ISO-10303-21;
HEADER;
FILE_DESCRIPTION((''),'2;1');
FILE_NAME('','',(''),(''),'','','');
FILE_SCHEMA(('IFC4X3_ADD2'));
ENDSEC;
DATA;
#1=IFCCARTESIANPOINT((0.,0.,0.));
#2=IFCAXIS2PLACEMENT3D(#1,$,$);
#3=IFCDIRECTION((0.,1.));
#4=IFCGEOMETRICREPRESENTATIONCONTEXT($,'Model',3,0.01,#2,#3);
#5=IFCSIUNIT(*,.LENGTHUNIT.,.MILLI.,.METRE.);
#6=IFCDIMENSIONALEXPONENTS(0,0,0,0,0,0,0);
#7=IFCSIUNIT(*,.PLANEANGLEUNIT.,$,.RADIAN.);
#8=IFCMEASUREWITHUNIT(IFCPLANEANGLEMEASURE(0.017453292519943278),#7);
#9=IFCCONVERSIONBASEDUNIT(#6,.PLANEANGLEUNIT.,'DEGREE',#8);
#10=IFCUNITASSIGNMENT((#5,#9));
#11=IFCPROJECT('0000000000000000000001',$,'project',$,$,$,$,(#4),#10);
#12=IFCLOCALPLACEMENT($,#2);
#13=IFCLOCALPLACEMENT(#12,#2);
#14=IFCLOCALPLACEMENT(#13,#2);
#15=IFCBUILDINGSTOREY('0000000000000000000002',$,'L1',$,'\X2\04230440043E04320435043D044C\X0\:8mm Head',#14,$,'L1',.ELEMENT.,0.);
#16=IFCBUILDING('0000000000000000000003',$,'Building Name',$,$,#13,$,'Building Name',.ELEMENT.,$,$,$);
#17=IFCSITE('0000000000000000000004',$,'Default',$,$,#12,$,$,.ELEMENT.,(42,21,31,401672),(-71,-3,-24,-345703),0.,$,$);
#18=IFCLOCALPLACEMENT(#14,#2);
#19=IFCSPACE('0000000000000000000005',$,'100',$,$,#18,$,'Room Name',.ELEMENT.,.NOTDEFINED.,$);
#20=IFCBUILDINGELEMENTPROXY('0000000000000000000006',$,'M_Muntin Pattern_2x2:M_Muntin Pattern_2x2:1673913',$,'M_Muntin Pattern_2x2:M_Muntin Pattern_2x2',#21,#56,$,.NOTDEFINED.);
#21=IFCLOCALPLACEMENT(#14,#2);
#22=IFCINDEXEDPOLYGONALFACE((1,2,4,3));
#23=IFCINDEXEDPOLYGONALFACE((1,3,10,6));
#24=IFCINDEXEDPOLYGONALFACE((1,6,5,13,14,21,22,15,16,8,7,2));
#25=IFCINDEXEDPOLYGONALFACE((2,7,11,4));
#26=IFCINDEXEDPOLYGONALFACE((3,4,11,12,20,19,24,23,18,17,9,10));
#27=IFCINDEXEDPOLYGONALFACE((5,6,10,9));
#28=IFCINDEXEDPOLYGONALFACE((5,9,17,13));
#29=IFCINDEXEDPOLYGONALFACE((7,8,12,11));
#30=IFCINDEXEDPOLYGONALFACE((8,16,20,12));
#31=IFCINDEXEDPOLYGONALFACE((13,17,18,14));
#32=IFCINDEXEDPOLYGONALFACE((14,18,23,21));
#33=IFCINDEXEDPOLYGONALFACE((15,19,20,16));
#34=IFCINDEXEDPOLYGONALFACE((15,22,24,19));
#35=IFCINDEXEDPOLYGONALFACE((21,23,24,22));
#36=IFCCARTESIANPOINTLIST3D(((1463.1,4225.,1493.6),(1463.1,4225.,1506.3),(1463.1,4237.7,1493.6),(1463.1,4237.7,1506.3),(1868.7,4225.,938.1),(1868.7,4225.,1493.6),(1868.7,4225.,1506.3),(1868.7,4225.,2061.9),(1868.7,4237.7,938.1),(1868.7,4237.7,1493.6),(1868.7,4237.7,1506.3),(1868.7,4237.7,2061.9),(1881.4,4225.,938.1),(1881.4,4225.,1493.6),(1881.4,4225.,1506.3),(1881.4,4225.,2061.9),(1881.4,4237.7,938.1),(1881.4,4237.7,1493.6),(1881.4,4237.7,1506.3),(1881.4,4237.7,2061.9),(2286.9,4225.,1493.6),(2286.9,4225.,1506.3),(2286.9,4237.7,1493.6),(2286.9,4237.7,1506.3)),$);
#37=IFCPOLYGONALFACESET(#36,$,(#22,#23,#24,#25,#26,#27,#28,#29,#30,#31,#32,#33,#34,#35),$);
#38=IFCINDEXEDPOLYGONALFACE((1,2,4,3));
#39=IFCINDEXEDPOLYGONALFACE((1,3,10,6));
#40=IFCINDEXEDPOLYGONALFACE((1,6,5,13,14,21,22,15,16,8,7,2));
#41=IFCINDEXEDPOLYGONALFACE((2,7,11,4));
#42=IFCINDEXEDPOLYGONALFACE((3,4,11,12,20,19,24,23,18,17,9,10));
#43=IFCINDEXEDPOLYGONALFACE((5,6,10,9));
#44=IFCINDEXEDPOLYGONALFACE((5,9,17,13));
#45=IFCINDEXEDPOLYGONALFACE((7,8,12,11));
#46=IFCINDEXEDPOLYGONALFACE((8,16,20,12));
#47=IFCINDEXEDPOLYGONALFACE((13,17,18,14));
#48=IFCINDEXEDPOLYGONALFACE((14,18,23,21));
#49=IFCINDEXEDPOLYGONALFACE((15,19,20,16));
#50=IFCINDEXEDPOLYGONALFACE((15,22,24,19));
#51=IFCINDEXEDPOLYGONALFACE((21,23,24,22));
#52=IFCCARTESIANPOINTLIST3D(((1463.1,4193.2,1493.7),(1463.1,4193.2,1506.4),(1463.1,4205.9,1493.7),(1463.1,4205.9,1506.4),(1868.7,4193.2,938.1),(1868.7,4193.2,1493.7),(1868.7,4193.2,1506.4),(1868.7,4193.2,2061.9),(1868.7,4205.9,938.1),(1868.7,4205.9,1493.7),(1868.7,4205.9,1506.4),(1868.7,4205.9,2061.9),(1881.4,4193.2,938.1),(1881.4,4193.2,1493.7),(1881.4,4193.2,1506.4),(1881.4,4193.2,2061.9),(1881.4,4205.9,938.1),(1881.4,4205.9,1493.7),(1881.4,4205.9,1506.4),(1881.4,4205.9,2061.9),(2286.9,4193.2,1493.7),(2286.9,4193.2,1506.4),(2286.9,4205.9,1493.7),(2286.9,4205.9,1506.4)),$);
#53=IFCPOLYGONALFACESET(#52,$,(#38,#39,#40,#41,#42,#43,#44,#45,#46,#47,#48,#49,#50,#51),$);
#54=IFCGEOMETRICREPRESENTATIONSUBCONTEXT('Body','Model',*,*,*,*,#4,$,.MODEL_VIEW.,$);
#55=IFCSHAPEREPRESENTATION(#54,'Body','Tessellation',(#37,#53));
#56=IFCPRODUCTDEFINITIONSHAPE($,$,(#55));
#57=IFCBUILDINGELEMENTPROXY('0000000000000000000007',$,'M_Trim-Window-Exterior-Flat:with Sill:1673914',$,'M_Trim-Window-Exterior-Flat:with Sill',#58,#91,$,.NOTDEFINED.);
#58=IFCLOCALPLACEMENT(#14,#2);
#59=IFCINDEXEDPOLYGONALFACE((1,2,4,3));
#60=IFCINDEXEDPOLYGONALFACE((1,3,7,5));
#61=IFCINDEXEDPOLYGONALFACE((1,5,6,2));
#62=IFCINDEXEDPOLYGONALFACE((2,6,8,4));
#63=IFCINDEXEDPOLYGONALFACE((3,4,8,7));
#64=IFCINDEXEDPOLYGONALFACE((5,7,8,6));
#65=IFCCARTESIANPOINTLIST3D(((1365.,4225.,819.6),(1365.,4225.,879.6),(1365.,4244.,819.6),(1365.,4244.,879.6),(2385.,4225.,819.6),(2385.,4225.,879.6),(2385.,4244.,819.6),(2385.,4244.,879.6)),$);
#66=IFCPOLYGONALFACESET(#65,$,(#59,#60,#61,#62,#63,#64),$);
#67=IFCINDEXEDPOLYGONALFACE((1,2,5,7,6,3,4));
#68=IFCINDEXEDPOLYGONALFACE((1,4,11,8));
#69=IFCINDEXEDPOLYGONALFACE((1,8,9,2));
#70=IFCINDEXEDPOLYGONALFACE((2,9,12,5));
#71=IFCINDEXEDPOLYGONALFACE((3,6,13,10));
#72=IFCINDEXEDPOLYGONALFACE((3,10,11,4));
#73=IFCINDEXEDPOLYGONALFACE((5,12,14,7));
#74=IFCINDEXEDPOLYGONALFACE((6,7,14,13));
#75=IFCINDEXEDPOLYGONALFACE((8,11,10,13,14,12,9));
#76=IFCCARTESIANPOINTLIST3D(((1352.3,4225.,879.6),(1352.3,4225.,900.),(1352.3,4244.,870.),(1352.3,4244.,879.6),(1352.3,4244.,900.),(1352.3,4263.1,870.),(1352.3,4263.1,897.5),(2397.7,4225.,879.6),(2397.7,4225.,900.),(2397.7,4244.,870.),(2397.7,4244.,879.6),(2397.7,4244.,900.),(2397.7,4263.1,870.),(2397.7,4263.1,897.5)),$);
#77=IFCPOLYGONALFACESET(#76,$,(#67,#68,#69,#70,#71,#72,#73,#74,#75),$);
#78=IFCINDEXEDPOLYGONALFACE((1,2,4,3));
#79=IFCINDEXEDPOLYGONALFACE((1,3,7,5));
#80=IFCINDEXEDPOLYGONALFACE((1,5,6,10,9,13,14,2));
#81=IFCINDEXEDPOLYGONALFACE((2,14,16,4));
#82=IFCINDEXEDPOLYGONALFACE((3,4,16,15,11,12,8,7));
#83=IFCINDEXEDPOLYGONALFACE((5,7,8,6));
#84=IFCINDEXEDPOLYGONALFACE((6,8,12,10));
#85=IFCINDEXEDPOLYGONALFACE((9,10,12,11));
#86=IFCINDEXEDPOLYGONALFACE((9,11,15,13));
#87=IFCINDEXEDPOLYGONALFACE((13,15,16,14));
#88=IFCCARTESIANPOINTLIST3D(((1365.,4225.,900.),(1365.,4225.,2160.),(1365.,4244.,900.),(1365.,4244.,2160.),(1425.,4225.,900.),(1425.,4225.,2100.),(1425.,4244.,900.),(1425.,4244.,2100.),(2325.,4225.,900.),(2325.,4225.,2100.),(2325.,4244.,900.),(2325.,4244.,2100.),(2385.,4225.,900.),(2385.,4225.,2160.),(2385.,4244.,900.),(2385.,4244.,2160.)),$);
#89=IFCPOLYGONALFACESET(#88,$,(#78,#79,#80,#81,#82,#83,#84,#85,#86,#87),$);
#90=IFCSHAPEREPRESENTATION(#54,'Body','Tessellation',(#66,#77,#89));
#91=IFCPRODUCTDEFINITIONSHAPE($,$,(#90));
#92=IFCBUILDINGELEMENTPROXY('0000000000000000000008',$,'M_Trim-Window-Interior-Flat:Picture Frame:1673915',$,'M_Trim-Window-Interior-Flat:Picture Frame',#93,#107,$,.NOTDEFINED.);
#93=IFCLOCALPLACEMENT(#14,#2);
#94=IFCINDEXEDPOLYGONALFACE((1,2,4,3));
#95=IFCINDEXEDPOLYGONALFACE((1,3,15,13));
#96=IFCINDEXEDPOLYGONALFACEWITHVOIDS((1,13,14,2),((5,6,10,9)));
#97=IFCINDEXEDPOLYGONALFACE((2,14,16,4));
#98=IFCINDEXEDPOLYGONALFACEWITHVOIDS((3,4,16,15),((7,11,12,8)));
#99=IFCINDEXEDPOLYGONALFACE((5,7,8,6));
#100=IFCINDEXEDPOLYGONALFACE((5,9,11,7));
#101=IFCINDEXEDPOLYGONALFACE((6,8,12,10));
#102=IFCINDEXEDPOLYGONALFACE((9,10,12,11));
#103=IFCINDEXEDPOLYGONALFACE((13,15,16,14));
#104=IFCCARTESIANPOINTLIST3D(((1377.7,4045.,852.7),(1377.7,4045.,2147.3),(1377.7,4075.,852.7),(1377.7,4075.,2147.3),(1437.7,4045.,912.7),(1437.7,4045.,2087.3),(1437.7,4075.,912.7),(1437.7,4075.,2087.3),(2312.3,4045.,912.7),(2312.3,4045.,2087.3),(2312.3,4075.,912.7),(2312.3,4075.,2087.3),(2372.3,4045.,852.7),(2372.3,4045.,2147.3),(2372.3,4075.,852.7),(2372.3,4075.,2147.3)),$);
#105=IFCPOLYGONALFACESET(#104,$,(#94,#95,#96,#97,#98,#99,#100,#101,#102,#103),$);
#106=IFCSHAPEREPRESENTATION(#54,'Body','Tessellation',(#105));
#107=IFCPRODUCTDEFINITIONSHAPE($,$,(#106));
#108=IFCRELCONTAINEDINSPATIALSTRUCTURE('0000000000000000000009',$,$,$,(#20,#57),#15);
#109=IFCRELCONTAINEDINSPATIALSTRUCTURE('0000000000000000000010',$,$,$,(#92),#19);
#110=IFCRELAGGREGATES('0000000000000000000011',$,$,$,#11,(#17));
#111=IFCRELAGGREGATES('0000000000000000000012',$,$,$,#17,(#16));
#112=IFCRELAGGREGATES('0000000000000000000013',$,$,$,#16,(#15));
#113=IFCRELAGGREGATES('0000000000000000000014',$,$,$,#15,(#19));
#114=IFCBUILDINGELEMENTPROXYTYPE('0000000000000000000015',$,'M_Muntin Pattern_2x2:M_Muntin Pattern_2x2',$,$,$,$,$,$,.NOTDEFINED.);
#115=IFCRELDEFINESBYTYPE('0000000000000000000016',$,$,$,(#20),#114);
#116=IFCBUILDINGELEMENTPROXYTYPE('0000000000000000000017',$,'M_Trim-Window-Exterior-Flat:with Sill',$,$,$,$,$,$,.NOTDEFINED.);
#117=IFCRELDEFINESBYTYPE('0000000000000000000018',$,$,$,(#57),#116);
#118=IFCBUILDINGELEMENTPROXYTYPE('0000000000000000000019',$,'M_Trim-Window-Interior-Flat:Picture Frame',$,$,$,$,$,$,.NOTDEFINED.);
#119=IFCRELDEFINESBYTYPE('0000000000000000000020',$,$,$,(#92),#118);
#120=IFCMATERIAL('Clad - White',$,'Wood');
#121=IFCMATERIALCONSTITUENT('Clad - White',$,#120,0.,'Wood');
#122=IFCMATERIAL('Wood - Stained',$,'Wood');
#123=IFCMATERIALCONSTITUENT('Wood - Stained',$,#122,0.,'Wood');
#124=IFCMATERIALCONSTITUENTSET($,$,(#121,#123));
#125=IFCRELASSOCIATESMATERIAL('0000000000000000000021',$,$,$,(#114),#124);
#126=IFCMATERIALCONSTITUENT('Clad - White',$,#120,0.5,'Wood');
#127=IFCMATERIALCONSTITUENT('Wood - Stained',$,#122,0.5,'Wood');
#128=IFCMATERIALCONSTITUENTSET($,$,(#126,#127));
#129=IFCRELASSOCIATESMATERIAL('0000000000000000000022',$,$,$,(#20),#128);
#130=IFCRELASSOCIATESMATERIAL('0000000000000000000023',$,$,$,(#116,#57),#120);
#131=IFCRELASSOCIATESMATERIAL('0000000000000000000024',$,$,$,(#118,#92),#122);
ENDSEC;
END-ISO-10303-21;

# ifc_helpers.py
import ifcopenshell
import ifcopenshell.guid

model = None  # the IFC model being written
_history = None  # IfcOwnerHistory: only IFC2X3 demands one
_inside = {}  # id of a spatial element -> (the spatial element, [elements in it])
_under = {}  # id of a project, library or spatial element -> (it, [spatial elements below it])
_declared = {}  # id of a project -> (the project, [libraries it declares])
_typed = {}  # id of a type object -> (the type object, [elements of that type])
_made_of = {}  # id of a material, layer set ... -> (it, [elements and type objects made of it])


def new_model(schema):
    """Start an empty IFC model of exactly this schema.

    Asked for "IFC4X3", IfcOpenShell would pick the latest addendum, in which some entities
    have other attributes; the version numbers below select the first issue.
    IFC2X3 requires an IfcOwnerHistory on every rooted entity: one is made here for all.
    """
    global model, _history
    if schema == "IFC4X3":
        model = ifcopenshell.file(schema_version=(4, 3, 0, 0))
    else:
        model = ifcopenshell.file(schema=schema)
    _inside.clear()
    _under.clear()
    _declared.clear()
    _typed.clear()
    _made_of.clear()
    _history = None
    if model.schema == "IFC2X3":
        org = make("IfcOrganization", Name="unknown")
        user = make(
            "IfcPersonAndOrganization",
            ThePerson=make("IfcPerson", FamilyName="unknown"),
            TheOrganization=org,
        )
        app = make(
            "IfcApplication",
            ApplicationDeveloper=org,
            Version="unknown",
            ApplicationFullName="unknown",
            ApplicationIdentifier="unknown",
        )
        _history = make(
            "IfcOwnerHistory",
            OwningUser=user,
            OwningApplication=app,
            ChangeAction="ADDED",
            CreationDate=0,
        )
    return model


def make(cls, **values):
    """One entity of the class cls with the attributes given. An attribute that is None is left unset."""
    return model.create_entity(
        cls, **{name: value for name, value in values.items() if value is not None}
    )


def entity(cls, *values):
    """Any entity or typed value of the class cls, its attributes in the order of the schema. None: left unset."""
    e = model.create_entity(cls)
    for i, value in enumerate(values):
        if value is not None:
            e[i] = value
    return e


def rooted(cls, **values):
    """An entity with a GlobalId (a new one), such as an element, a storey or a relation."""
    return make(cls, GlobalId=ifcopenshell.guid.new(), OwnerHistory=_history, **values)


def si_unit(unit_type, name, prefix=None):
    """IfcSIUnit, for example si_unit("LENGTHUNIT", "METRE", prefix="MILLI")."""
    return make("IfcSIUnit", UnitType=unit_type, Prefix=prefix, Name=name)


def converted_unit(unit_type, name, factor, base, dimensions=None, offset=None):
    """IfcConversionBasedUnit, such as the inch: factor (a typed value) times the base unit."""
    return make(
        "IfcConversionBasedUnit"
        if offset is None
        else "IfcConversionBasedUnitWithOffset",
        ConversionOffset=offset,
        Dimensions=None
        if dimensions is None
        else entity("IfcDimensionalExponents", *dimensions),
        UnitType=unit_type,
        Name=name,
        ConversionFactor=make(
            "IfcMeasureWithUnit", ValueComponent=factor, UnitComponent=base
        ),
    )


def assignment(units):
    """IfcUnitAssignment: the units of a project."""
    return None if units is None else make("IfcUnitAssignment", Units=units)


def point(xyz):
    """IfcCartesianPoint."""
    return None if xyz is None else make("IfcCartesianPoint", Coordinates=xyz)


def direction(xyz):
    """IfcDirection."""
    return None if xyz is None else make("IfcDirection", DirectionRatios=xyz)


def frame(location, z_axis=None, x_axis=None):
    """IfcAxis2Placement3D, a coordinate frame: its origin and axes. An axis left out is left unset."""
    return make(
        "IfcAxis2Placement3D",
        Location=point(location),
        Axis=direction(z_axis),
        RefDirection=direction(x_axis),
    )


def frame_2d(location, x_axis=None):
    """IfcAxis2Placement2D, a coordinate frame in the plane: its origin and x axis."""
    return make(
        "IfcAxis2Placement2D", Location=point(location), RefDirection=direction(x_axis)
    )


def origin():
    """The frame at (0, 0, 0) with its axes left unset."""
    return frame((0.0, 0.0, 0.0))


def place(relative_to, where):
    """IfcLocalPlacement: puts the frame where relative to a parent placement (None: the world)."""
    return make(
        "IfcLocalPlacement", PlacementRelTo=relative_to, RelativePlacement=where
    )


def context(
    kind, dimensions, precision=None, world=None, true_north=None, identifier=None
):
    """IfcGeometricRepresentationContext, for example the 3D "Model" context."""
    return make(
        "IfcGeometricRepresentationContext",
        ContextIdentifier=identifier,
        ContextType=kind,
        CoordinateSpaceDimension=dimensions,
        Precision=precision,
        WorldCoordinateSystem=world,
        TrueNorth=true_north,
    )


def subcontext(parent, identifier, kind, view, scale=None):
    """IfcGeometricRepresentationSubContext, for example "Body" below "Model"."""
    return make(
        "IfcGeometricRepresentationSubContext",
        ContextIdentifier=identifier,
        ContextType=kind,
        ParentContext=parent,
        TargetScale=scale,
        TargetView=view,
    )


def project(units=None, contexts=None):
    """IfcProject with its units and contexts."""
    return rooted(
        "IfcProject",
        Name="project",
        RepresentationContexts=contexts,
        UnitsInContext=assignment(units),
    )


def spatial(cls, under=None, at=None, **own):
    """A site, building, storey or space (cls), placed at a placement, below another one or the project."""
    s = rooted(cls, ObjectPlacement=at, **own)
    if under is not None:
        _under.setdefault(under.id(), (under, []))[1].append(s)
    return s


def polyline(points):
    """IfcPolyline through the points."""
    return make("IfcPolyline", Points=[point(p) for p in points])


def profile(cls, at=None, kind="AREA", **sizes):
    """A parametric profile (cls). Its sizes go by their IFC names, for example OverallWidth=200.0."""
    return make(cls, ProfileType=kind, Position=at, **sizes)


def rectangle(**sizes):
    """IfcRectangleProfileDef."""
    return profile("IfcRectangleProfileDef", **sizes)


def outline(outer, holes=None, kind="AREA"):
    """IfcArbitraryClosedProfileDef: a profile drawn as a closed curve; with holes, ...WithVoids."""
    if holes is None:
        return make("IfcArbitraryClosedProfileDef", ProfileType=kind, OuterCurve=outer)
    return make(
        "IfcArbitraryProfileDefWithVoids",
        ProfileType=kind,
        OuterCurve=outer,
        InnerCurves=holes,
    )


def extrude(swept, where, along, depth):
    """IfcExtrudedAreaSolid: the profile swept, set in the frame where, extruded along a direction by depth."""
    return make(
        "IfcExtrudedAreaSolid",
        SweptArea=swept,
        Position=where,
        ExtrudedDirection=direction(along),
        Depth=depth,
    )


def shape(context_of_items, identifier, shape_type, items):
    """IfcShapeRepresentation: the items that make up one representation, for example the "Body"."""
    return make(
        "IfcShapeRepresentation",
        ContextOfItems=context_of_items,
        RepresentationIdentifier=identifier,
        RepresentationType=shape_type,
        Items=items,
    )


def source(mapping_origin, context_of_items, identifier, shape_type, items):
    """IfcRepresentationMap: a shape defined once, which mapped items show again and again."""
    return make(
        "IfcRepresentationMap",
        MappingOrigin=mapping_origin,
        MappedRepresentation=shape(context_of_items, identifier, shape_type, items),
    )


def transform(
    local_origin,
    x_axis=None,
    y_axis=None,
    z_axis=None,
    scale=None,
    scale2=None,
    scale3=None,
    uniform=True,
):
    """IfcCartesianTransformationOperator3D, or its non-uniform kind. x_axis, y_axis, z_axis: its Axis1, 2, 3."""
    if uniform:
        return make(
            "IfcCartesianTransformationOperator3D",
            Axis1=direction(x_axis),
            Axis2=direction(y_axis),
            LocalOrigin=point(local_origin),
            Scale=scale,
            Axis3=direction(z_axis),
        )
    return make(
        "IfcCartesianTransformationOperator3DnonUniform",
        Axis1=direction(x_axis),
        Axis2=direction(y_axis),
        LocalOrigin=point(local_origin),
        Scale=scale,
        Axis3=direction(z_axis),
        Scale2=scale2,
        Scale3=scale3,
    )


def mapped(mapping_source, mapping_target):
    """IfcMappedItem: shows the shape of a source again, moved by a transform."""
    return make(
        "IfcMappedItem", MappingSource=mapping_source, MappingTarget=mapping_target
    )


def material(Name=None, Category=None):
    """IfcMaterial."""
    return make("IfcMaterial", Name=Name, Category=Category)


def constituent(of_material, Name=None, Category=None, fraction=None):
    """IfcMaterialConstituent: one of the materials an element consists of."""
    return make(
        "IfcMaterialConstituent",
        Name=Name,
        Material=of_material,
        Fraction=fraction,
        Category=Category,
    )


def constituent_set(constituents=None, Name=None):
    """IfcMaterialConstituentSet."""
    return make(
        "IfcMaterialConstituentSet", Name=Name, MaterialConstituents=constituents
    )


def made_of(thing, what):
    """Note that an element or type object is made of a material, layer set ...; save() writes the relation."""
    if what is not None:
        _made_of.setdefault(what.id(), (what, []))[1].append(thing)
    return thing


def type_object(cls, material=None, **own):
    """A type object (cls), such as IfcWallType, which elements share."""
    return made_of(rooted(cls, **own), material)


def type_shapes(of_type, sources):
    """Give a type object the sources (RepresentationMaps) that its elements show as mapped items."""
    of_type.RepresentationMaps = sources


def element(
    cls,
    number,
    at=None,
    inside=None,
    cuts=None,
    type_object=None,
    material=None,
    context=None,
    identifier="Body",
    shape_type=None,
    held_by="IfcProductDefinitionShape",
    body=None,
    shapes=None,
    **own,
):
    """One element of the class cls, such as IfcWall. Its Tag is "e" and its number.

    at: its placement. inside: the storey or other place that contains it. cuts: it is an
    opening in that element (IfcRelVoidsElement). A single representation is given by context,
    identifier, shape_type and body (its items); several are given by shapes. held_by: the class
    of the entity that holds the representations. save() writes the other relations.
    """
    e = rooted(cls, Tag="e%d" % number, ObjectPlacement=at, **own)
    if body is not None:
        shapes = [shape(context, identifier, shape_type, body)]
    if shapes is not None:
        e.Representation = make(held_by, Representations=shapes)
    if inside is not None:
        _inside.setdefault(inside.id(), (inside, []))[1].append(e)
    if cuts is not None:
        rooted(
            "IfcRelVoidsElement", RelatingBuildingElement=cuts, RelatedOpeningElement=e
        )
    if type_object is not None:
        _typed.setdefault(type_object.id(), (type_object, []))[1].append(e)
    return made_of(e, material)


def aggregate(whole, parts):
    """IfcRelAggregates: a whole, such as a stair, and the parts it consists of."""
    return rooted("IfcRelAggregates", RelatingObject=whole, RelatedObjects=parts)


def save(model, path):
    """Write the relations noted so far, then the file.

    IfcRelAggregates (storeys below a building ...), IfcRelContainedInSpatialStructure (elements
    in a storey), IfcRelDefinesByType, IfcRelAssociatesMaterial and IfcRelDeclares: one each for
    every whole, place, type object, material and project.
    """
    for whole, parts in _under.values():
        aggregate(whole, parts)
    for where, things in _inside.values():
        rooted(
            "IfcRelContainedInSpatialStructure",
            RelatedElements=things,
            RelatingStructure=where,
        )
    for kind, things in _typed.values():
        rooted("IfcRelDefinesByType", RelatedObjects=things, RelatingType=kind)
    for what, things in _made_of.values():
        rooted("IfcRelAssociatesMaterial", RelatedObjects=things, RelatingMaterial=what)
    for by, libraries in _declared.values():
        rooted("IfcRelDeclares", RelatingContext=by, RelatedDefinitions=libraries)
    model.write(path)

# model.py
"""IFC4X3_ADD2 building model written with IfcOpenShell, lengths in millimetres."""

from ifc_helpers import new_model, entity, si_unit, converted_unit, direction, frame, frame_2d, origin, place, context, subcontext, project, spatial, polyline, rectangle, outline, extrude, source, transform, mapped, material, constituent, constituent_set, type_object, type_shapes, element, save


model = new_model("IFC4X3_ADD2")

# Units and contexts
model_context = context("Model", 3, precision=0.01, world=origin(), true_north=direction((0.0, 1.0)))
body_context = subcontext(model_context, "Body", "Model", "MODEL_VIEW")
ifc_project = project(units=[si_unit("LENGTHUNIT", "METRE", prefix="MILLI"), converted_unit("PLANEANGLEUNIT", "DEGREE", entity("IfcPlaneAngleMeasure", 0.017453292519943278), si_unit("PLANEANGLEUNIT", "RADIAN"), dimensions=[0, 0, 0, 0, 0, 0, 0])], contexts=[model_context])

# Site, building, storey
site_placement = place(None, origin())
site = spatial("IfcSite", under=ifc_project, at=site_placement, Name="Default", CompositionType="ELEMENT", RefLatitude=(42, 21, 31, 401672), RefLongitude=(-71, -3, -24, -345703), RefElevation=0.0)
building_placement = place(site_placement, origin())
building = spatial("IfcBuilding", under=site, at=building_placement, Name="Building Name", LongName="Building Name", CompositionType="ELEMENT")
storey_placement = place(building_placement, origin())
storey = spatial("IfcBuildingStorey", under=building, at=storey_placement, Name="L1", ObjectType="Уровень:8mm Head", LongName="L1", CompositionType="ELEMENT", Elevation=0.0)

# Building element proxies
ifc_material_1 = material(Name="Clad - White", Category="Wood")
ifc_constituent_1 = constituent(ifc_material_1, Name="Clad - White", Category="Wood", fraction=0.5)
ifc_material_2 = material(Name="Wood - Stained", Category="Wood")
ifc_constituent_2 = constituent(ifc_material_2, Name="Wood - Stained", Category="Wood", fraction=0.5)
ifc_constituent_set_1 = constituent_set(constituents=[ifc_constituent_1, ifc_constituent_2])
ifc_constituent_3 = constituent(ifc_material_1, Name="Clad - White", Category="Wood", fraction=0.0)
ifc_constituent_4 = constituent(ifc_material_2, Name="Wood - Stained", Category="Wood", fraction=0.0)
ifc_constituent_set_2 = constituent_set(constituents=[ifc_constituent_3, ifc_constituent_4])
building_element_proxy_type_1 = type_object("IfcBuildingElementProxyType", Name="M_Muntin Pattern_2x2:M_Muntin Pattern_2x2", PredefinedType="NOTDEFINED", material=ifc_constituent_set_2)
shared_shape_1 = source(origin(), body_context, "Body", "SweptSolid", [
    extrude(outline(polyline([(6.4, -6.4), (561.9, -6.4), (561.9, 6.3), (6.4, 6.3), (6.4, 411.9), (-6.3, 411.9), (-6.3, 6.3), (-561.9, 6.3), (-561.9, -6.4), (-6.3, -6.4), (-6.3, -411.9), (6.4, -411.9), (6.4, -6.4)])), frame((0.0, -22.2, 561.9), z_axis=(0.0, 1.0, 0.0), x_axis=(0.0, 0.0, 1.0)), (0.0, 0.0, 1.0), 12.7),
    extrude(outline(polyline([(6.4, -6.4), (561.9, -6.4), (561.9, 6.3), (6.4, 6.3), (6.4, 411.9), (-6.3, 411.9), (-6.3, 6.3), (-561.9, 6.3), (-561.9, -6.4), (-6.3, -6.4), (-6.3, -411.9), (6.4, -411.9), (6.4, -6.4)])), frame((0.0, 9.5, 561.9), z_axis=(0.0, 1.0, 0.0), x_axis=(0.0, 0.0, 1.0)), (0.0, 0.0, 1.0), 12.7),
])
type_shapes(building_element_proxy_type_1, [shared_shape_1])
proxy_1_placement = place(storey_placement, frame((1875.0, 4215.5, 938.1), z_axis=(0.0, 0.0, 1.0), x_axis=(-1.0, 0.0, 0.0)))
element("IfcBuildingElementProxy", 1, at=proxy_1_placement, inside=storey, type_object=building_element_proxy_type_1, material=ifc_constituent_set_1, Name="M_Muntin Pattern_2x2:M_Muntin Pattern_2x2:1673913", ObjectType="M_Muntin Pattern_2x2:M_Muntin Pattern_2x2", PredefinedType="NOTDEFINED", context=body_context, shape_type="MappedRepresentation", body=[
    mapped(shared_shape_1, transform((0.0, 0.0, 0.0), scale=1.0)),
])
building_element_proxy_type_2 = type_object("IfcBuildingElementProxyType", Name="M_Trim-Window-Exterior-Flat:with Sill", PredefinedType="NOTDEFINED", material=ifc_material_1)
shared_shape_2 = source(origin(), body_context, "Body", "SweptSolid", [
    extrude(rectangle(XDim=1020.0, YDim=60.0, at=frame_2d((0.0, 0.0), x_axis=(1.0, 0.0))), frame((0.0, -1250.4, 0.0), z_axis=(0.0, 0.0, 1.0), x_axis=(-1.0, 0.0, 0.0)), (0.0, 0.0, 1.0), 19.0),
    extrude(outline(polyline([(-19.0, -15.2), (0.0, -15.2), (0.0, -5.7), (19.0, -5.7), (19.0, 14.8), (0.0, 14.8), (-19.0, 12.3), (-19.0, -15.2)])), frame((-522.7, -1214.8, 19.0), z_axis=(1.0, 0.0, 0.0), x_axis=(0.0, 0.0, -1.0)), (0.0, 0.0, 1.0), 1045.4),
    extrude(outline(polyline([(-645.0, -510.0), (615.0, -510.0), (615.0, -450.0), (-585.0, -450.0), (-585.0, 450.0), (615.0, 450.0), (615.0, 510.0), (-645.0, 510.0), (-645.0, -510.0)])), frame((0.0, -585.0, 0.0), z_axis=(0.0, 0.0, 1.0), x_axis=(0.0, -1.0, 0.0)), (0.0, 0.0, 1.0), 19.0),
])
type_shapes(building_element_proxy_type_2, [shared_shape_2])
proxy_2_placement = place(storey_placement, frame((1875.0, 4225.0, 2100.0), z_axis=(0.0, 1.0, 0.0), x_axis=(-1.0, 0.0, 0.0)))
element("IfcBuildingElementProxy", 2, at=proxy_2_placement, inside=storey, type_object=building_element_proxy_type_2, material=ifc_material_1, Name="M_Trim-Window-Exterior-Flat:with Sill:1673914", ObjectType="M_Trim-Window-Exterior-Flat:with Sill", PredefinedType="NOTDEFINED", context=body_context, shape_type="MappedRepresentation", body=[
    mapped(shared_shape_2, transform((0.0, 0.0, 0.0), scale=1.0)),
])

# Shared definitions
space_placement = place(storey_placement, origin())
space = spatial("IfcSpace", under=storey, at=space_placement, Name="100", LongName="Room Name", CompositionType="ELEMENT", PredefinedType="NOTDEFINED")

# Building element proxy
building_element_proxy_type_3 = type_object("IfcBuildingElementProxyType", Name="M_Trim-Window-Interior-Flat:Picture Frame", PredefinedType="NOTDEFINED", material=ifc_material_2)
shared_shape_3 = source(origin(), body_context, "Body", "SweptSolid", [
    extrude(outline(polyline([(-497.3, -647.3), (497.3, -647.3), (497.3, 647.3), (-497.3, 647.3), (-497.3, -647.3)]), holes=[polyline([(-437.3, -587.3), (-437.3, 587.3), (437.3, 587.3), (437.3, -587.3), (-437.3, -587.3)])]), frame((0.0, -600.0, 0.0), z_axis=(0.0, 0.0, 1.0), x_axis=(-1.0, 0.0, 0.0)), (0.0, 0.0, 1.0), 30.0),
])
type_shapes(building_element_proxy_type_3, [shared_shape_3])
proxy_3_placement = place(space_placement, frame((1875.0, 4075.0, 2100.0), z_axis=(0.0, -1.0, 0.0), x_axis=(1.0, 0.0, 0.0)))
element("IfcBuildingElementProxy", 3, at=proxy_3_placement, inside=space, type_object=building_element_proxy_type_3, material=ifc_material_2, Name="M_Trim-Window-Interior-Flat:Picture Frame:1673915", ObjectType="M_Trim-Window-Interior-Flat:Picture Frame", PredefinedType="NOTDEFINED", context=body_context, shape_type="MappedRepresentation", body=[
    mapped(shared_shape_3, transform((0.0, 0.0, 0.0), scale=1.0)),
])

save(model, "model.ifc")
